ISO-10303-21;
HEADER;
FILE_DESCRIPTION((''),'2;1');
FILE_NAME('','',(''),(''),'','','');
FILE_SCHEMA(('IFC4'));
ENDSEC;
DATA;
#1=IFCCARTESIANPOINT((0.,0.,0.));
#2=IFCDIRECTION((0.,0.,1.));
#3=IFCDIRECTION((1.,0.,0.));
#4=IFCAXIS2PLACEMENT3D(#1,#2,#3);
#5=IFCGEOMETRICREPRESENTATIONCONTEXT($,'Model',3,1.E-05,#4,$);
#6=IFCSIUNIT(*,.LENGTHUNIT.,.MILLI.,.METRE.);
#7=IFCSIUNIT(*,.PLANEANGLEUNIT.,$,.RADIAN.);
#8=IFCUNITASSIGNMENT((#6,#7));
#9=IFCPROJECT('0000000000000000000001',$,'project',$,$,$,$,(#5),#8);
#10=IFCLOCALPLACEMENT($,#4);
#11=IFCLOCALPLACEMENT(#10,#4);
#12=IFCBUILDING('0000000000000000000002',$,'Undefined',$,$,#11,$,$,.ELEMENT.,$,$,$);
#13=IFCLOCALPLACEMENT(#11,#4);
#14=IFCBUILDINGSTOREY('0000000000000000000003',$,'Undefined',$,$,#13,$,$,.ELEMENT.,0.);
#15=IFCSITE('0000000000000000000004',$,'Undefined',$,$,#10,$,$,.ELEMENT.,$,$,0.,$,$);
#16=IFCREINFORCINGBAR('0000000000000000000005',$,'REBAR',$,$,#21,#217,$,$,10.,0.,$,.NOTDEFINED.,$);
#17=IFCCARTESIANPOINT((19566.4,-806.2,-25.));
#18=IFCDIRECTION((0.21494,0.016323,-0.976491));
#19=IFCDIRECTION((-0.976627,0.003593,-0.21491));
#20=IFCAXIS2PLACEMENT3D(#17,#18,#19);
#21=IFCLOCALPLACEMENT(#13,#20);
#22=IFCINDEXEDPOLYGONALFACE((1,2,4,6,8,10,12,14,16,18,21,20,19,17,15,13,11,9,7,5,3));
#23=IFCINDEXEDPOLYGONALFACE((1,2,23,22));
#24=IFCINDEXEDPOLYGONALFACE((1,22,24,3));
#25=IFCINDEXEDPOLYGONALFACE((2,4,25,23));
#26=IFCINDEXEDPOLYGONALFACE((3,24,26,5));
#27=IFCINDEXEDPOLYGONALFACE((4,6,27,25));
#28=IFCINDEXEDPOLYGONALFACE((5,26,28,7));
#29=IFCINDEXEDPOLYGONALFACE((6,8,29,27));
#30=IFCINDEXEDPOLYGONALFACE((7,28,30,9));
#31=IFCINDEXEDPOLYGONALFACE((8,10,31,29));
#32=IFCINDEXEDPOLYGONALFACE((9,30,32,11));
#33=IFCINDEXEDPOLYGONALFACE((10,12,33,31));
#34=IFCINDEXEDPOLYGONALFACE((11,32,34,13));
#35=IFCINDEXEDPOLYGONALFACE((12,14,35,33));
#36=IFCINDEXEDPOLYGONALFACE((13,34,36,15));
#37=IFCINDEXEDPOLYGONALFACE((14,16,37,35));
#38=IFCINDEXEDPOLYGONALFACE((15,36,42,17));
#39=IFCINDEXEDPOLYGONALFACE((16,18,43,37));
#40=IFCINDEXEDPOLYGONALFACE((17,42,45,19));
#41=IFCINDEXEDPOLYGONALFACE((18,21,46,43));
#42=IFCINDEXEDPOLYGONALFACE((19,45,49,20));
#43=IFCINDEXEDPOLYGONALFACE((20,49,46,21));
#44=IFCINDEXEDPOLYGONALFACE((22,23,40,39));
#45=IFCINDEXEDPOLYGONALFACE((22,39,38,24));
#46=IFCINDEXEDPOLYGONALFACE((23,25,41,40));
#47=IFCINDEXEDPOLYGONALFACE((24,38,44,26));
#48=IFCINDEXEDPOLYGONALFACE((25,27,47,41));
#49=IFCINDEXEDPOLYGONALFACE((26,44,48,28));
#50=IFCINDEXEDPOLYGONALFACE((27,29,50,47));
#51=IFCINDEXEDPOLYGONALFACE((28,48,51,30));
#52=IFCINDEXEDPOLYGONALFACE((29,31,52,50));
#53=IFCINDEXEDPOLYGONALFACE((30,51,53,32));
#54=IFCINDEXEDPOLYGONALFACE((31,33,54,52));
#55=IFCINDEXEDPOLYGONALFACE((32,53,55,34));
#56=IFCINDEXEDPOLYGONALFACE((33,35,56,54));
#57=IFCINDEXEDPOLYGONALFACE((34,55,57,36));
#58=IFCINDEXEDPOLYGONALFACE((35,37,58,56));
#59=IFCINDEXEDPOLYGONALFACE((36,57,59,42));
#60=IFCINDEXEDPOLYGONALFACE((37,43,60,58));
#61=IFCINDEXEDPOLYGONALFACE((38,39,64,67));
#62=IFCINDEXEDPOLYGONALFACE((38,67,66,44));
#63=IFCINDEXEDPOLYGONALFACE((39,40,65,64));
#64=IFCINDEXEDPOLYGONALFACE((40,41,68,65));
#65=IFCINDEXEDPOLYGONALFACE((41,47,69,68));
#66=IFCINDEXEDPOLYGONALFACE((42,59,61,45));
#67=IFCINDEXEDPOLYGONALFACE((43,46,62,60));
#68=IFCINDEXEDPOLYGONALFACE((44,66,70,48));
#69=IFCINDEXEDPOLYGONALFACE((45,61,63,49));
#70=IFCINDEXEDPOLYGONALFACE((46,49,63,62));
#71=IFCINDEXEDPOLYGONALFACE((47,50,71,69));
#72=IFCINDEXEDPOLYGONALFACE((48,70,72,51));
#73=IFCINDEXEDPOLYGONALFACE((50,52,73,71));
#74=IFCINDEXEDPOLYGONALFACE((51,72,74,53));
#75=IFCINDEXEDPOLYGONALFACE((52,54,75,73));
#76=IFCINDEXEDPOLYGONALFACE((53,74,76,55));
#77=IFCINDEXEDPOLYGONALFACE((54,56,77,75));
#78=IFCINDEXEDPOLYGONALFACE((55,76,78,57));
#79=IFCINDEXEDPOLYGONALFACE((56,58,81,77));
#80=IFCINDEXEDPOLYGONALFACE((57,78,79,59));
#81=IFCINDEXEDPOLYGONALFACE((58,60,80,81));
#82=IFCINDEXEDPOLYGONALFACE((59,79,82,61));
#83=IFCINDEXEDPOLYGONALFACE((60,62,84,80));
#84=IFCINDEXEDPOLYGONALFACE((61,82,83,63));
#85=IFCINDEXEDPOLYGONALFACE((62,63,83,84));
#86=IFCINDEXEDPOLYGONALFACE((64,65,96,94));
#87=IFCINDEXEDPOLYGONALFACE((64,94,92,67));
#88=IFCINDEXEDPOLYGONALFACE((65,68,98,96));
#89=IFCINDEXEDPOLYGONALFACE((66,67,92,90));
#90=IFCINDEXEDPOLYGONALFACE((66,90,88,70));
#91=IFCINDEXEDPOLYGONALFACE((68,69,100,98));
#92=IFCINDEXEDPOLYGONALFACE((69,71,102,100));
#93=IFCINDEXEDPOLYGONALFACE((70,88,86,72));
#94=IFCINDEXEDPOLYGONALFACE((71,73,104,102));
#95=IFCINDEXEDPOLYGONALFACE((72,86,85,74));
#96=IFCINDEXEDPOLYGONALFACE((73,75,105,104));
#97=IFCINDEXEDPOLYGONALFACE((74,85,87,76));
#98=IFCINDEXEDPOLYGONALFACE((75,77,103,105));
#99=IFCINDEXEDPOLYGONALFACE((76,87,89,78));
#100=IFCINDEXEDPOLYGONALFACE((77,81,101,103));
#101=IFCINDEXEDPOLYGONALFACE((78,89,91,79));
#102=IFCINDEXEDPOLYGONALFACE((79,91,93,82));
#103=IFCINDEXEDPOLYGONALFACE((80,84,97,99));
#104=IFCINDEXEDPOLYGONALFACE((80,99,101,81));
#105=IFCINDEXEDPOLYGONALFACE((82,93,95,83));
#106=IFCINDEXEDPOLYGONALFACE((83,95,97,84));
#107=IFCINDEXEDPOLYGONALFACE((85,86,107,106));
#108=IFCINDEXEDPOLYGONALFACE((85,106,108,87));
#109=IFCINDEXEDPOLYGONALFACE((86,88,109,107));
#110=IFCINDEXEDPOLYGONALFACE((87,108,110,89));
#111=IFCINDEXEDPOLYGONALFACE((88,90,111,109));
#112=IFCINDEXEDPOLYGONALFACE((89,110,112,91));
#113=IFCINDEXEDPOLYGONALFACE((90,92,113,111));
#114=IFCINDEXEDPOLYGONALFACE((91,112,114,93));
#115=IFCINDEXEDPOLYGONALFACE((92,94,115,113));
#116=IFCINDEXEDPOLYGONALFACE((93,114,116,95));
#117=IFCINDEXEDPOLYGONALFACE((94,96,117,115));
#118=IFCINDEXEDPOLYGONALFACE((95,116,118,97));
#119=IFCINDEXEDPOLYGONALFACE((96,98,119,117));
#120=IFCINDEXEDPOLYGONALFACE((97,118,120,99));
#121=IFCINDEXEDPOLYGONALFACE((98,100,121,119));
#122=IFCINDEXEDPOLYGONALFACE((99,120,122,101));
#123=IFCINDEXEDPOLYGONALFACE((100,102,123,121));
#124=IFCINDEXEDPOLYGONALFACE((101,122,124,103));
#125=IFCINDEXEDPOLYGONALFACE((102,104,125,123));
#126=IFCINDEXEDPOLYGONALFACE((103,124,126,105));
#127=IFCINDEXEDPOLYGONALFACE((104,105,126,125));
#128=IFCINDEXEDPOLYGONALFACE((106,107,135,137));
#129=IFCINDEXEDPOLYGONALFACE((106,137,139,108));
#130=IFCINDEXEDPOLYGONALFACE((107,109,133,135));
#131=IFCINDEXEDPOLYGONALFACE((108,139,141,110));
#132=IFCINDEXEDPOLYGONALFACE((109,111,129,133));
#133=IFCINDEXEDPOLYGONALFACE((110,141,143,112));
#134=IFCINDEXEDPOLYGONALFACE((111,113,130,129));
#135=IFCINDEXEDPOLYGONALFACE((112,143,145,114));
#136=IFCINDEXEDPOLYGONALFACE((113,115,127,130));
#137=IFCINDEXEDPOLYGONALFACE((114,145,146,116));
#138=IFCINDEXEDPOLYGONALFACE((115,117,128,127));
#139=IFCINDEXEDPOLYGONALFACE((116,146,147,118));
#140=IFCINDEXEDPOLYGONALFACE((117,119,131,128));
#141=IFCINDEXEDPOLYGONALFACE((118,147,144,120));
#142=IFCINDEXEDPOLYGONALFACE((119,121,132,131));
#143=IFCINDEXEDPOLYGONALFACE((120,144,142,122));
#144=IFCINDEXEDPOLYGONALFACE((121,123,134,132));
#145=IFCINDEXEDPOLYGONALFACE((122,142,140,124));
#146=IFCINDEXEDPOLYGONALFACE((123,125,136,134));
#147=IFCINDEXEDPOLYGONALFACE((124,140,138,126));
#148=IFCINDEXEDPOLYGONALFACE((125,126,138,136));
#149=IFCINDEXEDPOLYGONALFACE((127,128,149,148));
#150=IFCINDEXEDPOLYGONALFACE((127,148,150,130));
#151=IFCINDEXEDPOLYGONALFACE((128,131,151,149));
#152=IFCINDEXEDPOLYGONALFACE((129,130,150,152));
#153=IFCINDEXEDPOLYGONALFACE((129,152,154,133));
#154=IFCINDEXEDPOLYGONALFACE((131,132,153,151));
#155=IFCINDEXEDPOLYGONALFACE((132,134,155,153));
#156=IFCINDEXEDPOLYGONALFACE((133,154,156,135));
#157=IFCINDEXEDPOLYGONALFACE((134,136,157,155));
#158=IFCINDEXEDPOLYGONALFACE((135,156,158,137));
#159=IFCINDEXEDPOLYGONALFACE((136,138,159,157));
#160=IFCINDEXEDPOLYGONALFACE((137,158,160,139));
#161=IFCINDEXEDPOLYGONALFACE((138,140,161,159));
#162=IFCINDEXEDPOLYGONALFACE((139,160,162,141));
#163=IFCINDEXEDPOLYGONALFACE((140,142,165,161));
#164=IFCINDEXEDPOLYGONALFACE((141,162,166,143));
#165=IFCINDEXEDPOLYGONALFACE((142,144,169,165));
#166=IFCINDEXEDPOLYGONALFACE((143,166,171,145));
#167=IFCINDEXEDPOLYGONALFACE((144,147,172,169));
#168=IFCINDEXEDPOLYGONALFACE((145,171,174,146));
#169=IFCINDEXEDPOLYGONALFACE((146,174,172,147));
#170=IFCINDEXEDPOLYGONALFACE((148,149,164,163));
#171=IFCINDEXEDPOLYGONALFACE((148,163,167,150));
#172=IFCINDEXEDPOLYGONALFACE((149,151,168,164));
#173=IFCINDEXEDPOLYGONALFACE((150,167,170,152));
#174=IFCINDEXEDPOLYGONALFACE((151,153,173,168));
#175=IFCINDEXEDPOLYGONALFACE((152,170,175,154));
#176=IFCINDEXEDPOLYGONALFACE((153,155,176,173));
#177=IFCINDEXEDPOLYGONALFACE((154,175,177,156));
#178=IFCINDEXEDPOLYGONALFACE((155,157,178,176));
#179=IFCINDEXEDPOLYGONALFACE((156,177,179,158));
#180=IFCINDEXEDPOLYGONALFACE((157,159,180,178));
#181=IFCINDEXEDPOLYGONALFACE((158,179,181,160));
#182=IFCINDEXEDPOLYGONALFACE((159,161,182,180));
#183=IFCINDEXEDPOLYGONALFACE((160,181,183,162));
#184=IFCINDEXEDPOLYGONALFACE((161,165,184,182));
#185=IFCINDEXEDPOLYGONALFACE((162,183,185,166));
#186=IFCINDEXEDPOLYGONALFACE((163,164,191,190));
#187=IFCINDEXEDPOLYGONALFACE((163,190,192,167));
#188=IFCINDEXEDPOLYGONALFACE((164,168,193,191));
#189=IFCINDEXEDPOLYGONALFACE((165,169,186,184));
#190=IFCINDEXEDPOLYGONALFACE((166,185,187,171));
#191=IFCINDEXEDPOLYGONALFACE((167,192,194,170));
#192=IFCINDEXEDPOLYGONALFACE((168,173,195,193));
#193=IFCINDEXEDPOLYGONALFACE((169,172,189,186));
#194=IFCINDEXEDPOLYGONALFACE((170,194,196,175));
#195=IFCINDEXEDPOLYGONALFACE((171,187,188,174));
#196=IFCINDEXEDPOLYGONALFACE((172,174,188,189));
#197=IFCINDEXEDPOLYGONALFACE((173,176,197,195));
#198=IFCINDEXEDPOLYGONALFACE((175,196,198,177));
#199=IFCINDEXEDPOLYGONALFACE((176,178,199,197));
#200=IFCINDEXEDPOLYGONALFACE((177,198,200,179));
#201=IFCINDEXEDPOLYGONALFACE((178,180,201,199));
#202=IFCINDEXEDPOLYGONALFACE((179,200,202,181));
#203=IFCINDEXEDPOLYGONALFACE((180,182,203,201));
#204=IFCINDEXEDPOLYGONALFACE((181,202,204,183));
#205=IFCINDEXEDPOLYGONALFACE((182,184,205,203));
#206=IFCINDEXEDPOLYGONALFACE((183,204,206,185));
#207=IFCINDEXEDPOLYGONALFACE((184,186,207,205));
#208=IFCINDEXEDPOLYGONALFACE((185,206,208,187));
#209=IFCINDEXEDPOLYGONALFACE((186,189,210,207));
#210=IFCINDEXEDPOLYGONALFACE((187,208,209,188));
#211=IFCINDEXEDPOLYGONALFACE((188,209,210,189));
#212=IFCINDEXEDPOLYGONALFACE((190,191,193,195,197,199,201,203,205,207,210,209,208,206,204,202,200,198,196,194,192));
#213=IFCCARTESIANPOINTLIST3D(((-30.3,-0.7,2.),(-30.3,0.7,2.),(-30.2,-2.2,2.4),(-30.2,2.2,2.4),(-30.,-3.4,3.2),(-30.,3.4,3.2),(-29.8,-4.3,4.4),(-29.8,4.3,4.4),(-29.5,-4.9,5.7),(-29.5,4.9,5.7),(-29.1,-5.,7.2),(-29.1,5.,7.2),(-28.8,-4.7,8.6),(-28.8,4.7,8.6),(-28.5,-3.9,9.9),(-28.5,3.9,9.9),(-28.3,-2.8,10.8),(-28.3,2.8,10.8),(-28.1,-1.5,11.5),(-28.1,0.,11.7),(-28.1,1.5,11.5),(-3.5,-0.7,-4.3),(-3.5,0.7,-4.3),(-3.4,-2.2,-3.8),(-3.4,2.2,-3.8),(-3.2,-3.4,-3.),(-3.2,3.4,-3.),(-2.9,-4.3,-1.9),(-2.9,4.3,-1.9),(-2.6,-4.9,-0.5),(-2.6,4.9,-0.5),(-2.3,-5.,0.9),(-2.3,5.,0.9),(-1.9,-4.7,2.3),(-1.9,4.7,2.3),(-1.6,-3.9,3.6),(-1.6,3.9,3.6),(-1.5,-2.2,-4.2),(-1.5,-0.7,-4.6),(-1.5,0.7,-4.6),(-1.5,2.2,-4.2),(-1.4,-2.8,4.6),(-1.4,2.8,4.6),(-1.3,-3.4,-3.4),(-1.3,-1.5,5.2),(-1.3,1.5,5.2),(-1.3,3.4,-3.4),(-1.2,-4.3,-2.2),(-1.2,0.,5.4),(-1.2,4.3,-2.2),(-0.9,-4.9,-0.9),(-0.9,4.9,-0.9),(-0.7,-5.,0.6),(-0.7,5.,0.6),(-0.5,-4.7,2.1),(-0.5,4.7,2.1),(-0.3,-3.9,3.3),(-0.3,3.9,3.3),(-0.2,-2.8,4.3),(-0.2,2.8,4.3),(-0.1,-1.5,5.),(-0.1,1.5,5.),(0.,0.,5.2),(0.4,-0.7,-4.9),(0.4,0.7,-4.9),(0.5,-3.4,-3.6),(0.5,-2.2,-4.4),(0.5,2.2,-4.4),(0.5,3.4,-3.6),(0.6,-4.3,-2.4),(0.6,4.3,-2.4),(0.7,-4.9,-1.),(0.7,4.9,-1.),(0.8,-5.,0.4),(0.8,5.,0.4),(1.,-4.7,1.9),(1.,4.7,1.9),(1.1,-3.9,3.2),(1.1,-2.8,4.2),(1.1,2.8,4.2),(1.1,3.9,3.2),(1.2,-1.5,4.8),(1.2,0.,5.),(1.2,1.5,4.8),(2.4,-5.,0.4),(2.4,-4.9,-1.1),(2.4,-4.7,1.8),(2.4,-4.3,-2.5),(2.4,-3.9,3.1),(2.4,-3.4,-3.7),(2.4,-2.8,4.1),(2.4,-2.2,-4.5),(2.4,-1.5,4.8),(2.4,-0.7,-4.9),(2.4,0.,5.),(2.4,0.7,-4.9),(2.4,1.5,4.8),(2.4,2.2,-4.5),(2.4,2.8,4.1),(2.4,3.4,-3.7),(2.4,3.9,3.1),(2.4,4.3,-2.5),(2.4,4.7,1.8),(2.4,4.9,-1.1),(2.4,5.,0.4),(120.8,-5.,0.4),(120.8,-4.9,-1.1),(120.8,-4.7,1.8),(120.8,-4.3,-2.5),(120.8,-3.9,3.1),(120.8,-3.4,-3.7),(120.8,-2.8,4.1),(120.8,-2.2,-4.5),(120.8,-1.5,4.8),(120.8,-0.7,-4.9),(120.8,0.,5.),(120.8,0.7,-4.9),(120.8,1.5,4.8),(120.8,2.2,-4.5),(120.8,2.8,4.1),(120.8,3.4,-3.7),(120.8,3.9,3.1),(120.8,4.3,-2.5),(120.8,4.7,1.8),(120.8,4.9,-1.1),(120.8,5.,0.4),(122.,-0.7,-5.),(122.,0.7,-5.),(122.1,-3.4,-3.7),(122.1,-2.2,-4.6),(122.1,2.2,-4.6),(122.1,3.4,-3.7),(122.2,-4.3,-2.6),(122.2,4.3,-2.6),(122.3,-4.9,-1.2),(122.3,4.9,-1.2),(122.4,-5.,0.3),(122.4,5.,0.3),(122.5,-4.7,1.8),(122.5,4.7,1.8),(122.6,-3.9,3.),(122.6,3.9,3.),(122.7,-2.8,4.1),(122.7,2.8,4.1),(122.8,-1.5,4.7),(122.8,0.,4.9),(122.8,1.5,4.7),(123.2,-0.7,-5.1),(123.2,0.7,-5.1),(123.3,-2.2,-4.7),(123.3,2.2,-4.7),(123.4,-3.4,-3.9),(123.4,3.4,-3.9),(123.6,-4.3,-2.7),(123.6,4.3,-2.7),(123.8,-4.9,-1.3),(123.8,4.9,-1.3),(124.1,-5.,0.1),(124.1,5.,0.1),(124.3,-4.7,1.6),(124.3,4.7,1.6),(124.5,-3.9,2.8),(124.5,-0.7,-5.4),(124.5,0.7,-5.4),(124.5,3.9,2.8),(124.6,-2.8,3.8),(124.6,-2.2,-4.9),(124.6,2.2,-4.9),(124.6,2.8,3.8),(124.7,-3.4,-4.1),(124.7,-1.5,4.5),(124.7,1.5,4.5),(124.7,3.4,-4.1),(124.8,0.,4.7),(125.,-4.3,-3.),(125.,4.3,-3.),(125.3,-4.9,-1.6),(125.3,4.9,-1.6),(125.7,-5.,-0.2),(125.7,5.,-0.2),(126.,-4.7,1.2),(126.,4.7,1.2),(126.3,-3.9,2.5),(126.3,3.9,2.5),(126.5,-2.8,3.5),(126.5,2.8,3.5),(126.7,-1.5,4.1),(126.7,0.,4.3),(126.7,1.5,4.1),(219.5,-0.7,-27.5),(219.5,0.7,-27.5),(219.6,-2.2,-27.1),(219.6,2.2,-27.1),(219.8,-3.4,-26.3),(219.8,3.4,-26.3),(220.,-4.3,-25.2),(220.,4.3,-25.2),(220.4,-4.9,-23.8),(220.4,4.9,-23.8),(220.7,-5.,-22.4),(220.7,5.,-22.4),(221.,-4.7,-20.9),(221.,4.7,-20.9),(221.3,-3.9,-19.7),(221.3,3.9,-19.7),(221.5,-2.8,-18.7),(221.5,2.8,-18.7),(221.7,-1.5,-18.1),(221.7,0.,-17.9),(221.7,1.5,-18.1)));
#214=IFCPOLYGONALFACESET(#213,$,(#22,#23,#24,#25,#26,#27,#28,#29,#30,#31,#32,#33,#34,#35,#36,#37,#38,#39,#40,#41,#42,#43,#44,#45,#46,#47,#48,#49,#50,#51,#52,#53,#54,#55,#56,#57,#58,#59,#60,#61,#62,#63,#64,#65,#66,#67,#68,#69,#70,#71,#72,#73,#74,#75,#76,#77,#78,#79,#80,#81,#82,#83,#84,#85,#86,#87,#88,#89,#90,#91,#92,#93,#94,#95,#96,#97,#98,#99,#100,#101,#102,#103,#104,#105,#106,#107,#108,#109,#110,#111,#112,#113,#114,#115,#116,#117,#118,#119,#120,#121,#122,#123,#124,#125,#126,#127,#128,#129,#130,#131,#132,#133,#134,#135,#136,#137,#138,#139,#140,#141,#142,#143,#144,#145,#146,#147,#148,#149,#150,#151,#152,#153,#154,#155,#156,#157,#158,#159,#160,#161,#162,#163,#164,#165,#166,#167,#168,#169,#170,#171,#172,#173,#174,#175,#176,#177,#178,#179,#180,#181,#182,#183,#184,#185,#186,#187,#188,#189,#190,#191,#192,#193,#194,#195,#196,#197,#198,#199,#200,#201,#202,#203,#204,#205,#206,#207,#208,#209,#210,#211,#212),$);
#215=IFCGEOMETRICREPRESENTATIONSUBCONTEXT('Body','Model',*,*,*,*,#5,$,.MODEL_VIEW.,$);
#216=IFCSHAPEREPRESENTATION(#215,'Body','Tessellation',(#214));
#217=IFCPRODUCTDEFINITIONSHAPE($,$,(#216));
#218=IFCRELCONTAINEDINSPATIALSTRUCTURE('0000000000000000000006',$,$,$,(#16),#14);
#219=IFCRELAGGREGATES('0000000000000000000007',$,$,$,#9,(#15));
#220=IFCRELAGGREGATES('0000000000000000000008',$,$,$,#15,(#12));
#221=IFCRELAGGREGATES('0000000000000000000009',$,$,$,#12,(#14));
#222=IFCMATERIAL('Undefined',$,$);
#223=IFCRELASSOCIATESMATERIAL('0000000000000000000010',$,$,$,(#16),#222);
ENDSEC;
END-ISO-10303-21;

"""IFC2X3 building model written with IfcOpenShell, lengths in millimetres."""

from ifc_helpers import new_model, entity, si_unit, frame, origin_with_axes, place, context, subcontext, project, spatial, source, transform, mapped, material, element, save


model = new_model("IFC2X3")

# Units and contexts
model_context = context("Model", 3, precision=1e-05, world=origin_with_axes())
body_context = subcontext(model_context, "Body", "Model", "MODEL_VIEW")
ifc_project = project(units=[si_unit("LENGTHUNIT", "METRE", prefix="MILLI"), si_unit("PLANEANGLEUNIT", "RADIAN")], contexts=[model_context])

# Site, building, storey
site_placement = place(None, origin_with_axes())
site = spatial("IfcSite", under=ifc_project, at=site_placement, Name="Undefined", CompositionType="ELEMENT", RefElevation=0.0)
building_placement = place(site_placement, origin_with_axes())
building = spatial("IfcBuilding", under=site, at=building_placement, Name="Undefined", CompositionType="ELEMENT")
storey_placement = place(building_placement, origin_with_axes())
storey = spatial("IfcBuildingStorey", under=building, at=storey_placement, Name="Undefined", CompositionType="ELEMENT", Elevation=0.0)

# Reinforcing bar
ifc_material_1 = material(Name="Undefined")
vector = entity("IfcVector", entity("IfcDirection", [0.973841, 0.0, -0.22723]), 1.0)
shared_shape_1 = source(origin_with_axes(), body_context, "Body", "AdvancedSweptSolid", [
    entity("IfcSweptDiskSolid", entity("IfcCompositeCurve", [entity("IfcCompositeCurveSegment", "CONTINUOUS", True, entity("IfcTrimmedCurve", entity("IfcLine", entity("IfcCartesianPoint", [0.0, 0.0, 0.0]), vector), [entity("IfcParameterValue", 0.0)], [entity("IfcParameterValue", 27.582469)], True, "PARAMETER")), entity("IfcCompositeCurveSegment", "CONTINUOUS", True, entity("IfcTrimmedCurve", entity("IfcCircle", entity("IfcAxis2Placement3D", entity("IfcCartesianPoint", [31.6, 0.0, 14.2]), entity("IfcDirection", [0.0, -1.0, 0.0]), entity("IfcDirection", [-0.22723, 0.0, -0.973841])), 21.0), [entity("IfcParameterValue", 0.0)], [entity("IfcParameterValue", 0.229232)], True, "PARAMETER")), entity("IfcCompositeCurveSegment", "CONTINUOUS", True, entity("IfcTrimmedCurve", entity("IfcLine", entity("IfcCartesianPoint", [31.6, 0.0, -6.8]), entity("IfcVector", entity("IfcDirection", [1.0, 0.0, 0.0]), 1.0)), [entity("IfcParameterValue", 0.0)], [entity("IfcParameterValue", 118.388313)], True, "PARAMETER")), entity("IfcCompositeCurveSegment", "CONTINUOUS", True, entity("IfcTrimmedCurve", entity("IfcCircle", entity("IfcAxis2Placement3D", entity("IfcCartesianPoint", [150.0, 0.0, -27.8]), entity("IfcDirection", [0.0, 1.0, 0.0]), entity("IfcDirection", [0.0, 0.0, 1.0])), 21.0), [entity("IfcParameterValue", 0.0)], [entity("IfcParameterValue", 0.229232)], True, "PARAMETER")), entity("IfcCompositeCurveSegment", "DISCONTINUOUS", True, entity("IfcTrimmedCurve", entity("IfcLine", entity("IfcCartesianPoint", [154.8, 0.0, -7.4]), vector), [entity("IfcParameterValue", 0.0)], [entity("IfcParameterValue", 97.582469)], True, "PARAMETER"))], False), 5.0, None, 0.0, 244.0),
])
reinforcing_bar_1_placement = place(storey_placement, frame((19566.4, -806.2, -25.0), z_axis=(0.21494, 0.016323, -0.976491), x_axis=(-0.976627, 0.003593, -0.21491)))
element("IfcReinforcingBar", 1, at=reinforcing_bar_1_placement, inside=storey, material=ifc_material_1, Name="REBAR", BarRole="NOTDEFINED", CrossSectionArea=0.0, NominalDiameter=10.0, context=body_context, shape_type="MappedRepresentation", body=[
    mapped(shared_shape_1, transform((-29.2, 0.0, 6.8))),
])

save(model, "model.ifc")
